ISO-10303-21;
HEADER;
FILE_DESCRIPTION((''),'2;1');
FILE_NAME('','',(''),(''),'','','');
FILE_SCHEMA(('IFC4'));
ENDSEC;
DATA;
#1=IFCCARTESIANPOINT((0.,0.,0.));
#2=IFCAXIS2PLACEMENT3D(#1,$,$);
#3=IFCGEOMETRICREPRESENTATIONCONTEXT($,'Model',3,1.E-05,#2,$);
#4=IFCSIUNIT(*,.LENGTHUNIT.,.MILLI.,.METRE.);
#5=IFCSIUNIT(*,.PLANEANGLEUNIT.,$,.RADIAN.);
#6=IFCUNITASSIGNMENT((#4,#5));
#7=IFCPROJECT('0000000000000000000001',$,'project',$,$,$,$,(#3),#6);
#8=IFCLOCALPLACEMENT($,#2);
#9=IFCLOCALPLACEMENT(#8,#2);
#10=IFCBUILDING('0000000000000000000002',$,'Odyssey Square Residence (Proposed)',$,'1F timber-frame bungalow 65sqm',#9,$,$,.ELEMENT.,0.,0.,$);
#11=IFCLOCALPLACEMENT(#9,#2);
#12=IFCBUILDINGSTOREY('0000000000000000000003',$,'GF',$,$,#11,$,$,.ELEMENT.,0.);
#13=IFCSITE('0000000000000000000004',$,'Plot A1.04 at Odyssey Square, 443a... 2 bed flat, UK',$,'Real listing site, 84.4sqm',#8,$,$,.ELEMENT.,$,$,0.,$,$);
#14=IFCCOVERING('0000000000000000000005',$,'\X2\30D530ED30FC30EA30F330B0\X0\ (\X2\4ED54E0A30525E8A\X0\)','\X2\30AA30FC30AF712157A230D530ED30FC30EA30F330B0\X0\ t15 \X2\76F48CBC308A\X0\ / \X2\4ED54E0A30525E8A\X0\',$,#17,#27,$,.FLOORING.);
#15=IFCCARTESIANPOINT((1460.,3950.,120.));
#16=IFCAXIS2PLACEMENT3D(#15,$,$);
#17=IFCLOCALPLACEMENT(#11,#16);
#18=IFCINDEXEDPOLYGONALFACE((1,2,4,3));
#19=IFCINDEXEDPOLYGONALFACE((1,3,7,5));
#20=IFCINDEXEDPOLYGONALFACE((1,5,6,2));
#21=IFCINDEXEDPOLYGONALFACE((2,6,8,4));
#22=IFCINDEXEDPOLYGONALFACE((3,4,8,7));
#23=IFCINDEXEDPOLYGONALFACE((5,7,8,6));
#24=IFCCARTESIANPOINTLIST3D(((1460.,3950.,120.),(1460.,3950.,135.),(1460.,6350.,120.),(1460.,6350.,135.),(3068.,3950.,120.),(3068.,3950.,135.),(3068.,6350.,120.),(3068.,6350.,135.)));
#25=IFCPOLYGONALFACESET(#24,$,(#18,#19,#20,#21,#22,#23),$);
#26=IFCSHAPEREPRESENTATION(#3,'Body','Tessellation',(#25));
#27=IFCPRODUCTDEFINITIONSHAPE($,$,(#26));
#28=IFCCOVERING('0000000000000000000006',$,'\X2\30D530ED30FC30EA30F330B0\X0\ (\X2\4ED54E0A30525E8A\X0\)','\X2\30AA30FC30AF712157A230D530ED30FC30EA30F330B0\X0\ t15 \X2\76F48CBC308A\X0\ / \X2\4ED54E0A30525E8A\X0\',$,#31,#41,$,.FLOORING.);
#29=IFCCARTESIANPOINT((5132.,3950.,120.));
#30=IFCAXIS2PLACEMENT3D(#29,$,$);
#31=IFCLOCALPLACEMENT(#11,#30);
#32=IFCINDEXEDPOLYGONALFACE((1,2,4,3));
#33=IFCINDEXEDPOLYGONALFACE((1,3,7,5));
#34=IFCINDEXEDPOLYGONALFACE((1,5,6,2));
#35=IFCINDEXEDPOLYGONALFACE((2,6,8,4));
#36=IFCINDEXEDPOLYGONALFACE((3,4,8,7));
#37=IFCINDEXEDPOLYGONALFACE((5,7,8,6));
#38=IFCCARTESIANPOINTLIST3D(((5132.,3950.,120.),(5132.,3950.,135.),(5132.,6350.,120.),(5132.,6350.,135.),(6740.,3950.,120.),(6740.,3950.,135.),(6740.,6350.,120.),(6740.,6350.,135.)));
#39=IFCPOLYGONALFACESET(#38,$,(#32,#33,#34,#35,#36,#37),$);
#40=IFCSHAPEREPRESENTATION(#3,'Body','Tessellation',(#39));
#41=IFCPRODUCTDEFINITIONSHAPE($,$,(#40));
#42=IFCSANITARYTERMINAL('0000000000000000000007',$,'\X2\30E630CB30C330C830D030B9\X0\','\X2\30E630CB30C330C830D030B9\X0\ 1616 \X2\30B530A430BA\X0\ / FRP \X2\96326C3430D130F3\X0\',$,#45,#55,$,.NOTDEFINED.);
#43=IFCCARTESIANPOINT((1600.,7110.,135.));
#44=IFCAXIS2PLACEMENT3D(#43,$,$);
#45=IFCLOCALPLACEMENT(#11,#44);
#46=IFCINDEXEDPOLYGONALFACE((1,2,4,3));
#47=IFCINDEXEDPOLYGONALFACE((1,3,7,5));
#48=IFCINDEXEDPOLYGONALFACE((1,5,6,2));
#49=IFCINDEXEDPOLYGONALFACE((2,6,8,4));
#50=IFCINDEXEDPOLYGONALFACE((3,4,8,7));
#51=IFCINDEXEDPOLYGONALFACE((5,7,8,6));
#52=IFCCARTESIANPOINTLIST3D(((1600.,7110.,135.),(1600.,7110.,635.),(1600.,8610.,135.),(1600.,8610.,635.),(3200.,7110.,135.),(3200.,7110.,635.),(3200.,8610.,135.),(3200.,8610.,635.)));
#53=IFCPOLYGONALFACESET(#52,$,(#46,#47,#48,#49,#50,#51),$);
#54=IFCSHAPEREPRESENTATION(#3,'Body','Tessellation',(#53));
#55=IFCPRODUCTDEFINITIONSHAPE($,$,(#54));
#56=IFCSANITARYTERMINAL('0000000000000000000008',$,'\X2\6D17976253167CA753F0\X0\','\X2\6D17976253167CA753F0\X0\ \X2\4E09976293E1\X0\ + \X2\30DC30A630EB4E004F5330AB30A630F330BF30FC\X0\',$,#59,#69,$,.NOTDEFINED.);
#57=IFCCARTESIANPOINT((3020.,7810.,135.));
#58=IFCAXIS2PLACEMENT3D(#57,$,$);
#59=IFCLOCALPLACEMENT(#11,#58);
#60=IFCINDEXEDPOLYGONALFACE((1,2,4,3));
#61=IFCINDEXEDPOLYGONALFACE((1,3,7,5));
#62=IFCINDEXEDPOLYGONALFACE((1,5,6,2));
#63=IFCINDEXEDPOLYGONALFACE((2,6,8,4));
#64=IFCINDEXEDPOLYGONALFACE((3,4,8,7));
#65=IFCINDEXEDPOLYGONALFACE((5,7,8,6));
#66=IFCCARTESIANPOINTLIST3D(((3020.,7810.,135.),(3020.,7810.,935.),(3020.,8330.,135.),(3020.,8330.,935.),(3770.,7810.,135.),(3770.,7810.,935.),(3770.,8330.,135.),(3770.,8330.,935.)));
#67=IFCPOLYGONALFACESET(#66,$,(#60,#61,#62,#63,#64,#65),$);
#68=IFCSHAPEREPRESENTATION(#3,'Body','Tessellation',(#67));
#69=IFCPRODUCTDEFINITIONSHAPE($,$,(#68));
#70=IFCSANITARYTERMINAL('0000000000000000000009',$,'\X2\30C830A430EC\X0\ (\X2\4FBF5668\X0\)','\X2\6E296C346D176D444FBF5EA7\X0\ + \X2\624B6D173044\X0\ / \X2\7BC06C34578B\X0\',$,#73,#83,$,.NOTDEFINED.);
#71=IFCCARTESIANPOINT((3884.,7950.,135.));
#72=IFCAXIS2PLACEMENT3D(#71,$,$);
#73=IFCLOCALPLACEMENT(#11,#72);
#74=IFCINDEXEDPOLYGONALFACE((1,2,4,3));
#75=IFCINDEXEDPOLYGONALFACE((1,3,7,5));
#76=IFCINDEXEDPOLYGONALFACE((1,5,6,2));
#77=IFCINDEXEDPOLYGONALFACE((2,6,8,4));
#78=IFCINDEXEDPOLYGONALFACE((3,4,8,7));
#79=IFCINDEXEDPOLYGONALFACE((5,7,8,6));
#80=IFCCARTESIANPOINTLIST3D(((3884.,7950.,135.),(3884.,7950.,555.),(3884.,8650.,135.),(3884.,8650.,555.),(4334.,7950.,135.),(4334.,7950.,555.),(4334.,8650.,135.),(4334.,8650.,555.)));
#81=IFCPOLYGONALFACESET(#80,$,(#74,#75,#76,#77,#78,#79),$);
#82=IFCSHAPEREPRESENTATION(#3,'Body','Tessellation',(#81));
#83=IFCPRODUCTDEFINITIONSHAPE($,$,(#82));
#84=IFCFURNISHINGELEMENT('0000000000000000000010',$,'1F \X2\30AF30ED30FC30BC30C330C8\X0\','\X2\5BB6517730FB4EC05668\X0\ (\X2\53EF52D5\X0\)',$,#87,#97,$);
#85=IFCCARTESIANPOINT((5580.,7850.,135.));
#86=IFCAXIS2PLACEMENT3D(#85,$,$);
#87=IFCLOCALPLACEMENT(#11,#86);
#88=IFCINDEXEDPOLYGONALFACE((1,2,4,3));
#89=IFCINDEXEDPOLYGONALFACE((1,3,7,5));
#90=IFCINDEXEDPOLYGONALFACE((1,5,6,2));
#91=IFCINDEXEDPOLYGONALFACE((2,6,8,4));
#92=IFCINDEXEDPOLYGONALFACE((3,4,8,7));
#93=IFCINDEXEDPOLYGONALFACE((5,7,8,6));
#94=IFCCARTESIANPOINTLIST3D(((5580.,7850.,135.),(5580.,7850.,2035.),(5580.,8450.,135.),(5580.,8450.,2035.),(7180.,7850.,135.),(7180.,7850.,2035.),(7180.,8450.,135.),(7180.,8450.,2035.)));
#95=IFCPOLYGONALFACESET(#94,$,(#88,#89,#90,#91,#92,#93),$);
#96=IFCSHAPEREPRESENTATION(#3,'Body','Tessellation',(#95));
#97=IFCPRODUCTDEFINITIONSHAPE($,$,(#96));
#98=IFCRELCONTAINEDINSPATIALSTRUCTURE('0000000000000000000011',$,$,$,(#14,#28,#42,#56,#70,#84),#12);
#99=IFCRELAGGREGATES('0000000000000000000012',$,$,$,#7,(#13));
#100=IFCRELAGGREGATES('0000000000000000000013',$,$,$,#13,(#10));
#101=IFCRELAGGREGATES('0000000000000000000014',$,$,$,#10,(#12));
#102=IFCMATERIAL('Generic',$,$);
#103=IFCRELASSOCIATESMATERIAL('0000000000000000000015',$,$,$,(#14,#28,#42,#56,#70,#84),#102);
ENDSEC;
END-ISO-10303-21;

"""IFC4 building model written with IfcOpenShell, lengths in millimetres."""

from ifc_helpers import new_model, si_unit, frame, frame_2d, origin, place, context, project, spatial, rectangle, extrude, material, element, save


model = new_model("IFC4")

# Units and contexts
model_context = context("Model", 3, precision=1e-05, world=origin())
ifc_project = project(units=[si_unit("LENGTHUNIT", "METRE", prefix="MILLI"), si_unit("PLANEANGLEUNIT", "RADIAN")], contexts=[model_context])

# Site, building, storey
site_placement = place(None, origin())
site = spatial("IfcSite", under=ifc_project, at=site_placement, Name="Plot A1.04 at Odyssey Square, 443a... 2 bed flat, UK", ObjectType="Real listing site, 84.4sqm", CompositionType="ELEMENT", RefElevation=0.0)
building_placement = place(site_placement, origin())
building = spatial("IfcBuilding", under=site, at=building_placement, Name="Odyssey Square Residence (Proposed)", ObjectType="1F timber-frame bungalow 65sqm", CompositionType="ELEMENT", ElevationOfRefHeight=0.0, ElevationOfTerrain=0.0)
storey_placement = place(building_placement, origin())
storey = spatial("IfcBuildingStorey", under=building, at=storey_placement, Name="GF", CompositionType="ELEMENT", Elevation=0.0)

# Coverings
ifc_material_1 = material(Name="Generic")
covering_1_placement = place(storey_placement, frame((1460.0, 3950.0, 120.0)))
element("IfcCovering", 1, at=covering_1_placement, inside=storey, material=ifc_material_1, Name="フローリング (仕上げ床)", Description="オーク無垢フローリング t15 直貼り / 仕上げ床", PredefinedType="FLOORING", context=model_context, shape_type="SweptSolid", body=[
    extrude(rectangle(XDim=1608.0, YDim=2400.0, at=frame_2d((804.0, 1200.0))), frame((1460.0, 3950.0, 120.0)), (0.0, 0.0, 1.0), 15.0),
])
covering_2_placement = place(storey_placement, frame((5132.0, 3950.0, 120.0)))
element("IfcCovering", 2, at=covering_2_placement, inside=storey, material=ifc_material_1, Name="フローリング (仕上げ床)", Description="オーク無垢フローリング t15 直貼り / 仕上げ床", PredefinedType="FLOORING", context=model_context, shape_type="SweptSolid", body=[
    extrude(rectangle(XDim=1608.0, YDim=2400.0, at=frame_2d((804.0, 1200.0))), frame((5132.0, 3950.0, 120.0)), (0.0, 0.0, 1.0), 15.0),
])

# Sanitary terminals
sanitary_terminal_1_placement = place(storey_placement, frame((1600.0, 7110.0, 135.0)))
element("IfcSanitaryTerminal", 3, at=sanitary_terminal_1_placement, inside=storey, material=ifc_material_1, Name="ユニットバス", Description="ユニットバス 1616 サイズ / FRP 防水パン", PredefinedType="NOTDEFINED", context=model_context, shape_type="SweptSolid", body=[
    extrude(rectangle(XDim=1600.0, YDim=1500.0, at=frame_2d((800.0, 750.0))), frame((1600.0, 7110.0, 135.0)), (0.0, 0.0, 1.0), 500.0),
])
sanitary_terminal_2_placement = place(storey_placement, frame((3020.0, 7810.0, 135.0)))
element("IfcSanitaryTerminal", 4, at=sanitary_terminal_2_placement, inside=storey, material=ifc_material_1, Name="洗面化粧台", Description="洗面化粧台 三面鏡 + ボウル一体カウンター", PredefinedType="NOTDEFINED", context=model_context, shape_type="SweptSolid", body=[
    extrude(rectangle(XDim=750.0, YDim=520.0, at=frame_2d((375.0, 260.0))), frame((3020.0, 7810.0, 135.0)), (0.0, 0.0, 1.0), 800.0),
])
sanitary_terminal_3_placement = place(storey_placement, frame((3884.0, 7950.0, 135.0)))
element("IfcSanitaryTerminal", 5, at=sanitary_terminal_3_placement, inside=storey, material=ifc_material_1, Name="トイレ (便器)", Description="温水洗浄便座 + 手洗い / 節水型", PredefinedType="NOTDEFINED", context=model_context, shape_type="SweptSolid", body=[
    extrude(rectangle(XDim=450.0, YDim=700.0, at=frame_2d((225.0, 350.0))), frame((3884.0, 7950.0, 135.0)), (0.0, 0.0, 1.0), 420.0),
])

# Furnishing element
furnishing_placement = place(storey_placement, frame((5580.0, 7850.0, 135.0)))
element("IfcFurnishingElement", 6, at=furnishing_placement, inside=storey, material=ifc_material_1, Name="1F クローゼット", Description="家具・什器 (可動)", context=model_context, shape_type="SweptSolid", body=[
    extrude(rectangle(XDim=1600.0, YDim=600.0, at=frame_2d((800.0, 300.0))), frame((5580.0, 7850.0, 135.0)), (0.0, 0.0, 1.0), 1900.0),
])

save(model, "model.ifc")
